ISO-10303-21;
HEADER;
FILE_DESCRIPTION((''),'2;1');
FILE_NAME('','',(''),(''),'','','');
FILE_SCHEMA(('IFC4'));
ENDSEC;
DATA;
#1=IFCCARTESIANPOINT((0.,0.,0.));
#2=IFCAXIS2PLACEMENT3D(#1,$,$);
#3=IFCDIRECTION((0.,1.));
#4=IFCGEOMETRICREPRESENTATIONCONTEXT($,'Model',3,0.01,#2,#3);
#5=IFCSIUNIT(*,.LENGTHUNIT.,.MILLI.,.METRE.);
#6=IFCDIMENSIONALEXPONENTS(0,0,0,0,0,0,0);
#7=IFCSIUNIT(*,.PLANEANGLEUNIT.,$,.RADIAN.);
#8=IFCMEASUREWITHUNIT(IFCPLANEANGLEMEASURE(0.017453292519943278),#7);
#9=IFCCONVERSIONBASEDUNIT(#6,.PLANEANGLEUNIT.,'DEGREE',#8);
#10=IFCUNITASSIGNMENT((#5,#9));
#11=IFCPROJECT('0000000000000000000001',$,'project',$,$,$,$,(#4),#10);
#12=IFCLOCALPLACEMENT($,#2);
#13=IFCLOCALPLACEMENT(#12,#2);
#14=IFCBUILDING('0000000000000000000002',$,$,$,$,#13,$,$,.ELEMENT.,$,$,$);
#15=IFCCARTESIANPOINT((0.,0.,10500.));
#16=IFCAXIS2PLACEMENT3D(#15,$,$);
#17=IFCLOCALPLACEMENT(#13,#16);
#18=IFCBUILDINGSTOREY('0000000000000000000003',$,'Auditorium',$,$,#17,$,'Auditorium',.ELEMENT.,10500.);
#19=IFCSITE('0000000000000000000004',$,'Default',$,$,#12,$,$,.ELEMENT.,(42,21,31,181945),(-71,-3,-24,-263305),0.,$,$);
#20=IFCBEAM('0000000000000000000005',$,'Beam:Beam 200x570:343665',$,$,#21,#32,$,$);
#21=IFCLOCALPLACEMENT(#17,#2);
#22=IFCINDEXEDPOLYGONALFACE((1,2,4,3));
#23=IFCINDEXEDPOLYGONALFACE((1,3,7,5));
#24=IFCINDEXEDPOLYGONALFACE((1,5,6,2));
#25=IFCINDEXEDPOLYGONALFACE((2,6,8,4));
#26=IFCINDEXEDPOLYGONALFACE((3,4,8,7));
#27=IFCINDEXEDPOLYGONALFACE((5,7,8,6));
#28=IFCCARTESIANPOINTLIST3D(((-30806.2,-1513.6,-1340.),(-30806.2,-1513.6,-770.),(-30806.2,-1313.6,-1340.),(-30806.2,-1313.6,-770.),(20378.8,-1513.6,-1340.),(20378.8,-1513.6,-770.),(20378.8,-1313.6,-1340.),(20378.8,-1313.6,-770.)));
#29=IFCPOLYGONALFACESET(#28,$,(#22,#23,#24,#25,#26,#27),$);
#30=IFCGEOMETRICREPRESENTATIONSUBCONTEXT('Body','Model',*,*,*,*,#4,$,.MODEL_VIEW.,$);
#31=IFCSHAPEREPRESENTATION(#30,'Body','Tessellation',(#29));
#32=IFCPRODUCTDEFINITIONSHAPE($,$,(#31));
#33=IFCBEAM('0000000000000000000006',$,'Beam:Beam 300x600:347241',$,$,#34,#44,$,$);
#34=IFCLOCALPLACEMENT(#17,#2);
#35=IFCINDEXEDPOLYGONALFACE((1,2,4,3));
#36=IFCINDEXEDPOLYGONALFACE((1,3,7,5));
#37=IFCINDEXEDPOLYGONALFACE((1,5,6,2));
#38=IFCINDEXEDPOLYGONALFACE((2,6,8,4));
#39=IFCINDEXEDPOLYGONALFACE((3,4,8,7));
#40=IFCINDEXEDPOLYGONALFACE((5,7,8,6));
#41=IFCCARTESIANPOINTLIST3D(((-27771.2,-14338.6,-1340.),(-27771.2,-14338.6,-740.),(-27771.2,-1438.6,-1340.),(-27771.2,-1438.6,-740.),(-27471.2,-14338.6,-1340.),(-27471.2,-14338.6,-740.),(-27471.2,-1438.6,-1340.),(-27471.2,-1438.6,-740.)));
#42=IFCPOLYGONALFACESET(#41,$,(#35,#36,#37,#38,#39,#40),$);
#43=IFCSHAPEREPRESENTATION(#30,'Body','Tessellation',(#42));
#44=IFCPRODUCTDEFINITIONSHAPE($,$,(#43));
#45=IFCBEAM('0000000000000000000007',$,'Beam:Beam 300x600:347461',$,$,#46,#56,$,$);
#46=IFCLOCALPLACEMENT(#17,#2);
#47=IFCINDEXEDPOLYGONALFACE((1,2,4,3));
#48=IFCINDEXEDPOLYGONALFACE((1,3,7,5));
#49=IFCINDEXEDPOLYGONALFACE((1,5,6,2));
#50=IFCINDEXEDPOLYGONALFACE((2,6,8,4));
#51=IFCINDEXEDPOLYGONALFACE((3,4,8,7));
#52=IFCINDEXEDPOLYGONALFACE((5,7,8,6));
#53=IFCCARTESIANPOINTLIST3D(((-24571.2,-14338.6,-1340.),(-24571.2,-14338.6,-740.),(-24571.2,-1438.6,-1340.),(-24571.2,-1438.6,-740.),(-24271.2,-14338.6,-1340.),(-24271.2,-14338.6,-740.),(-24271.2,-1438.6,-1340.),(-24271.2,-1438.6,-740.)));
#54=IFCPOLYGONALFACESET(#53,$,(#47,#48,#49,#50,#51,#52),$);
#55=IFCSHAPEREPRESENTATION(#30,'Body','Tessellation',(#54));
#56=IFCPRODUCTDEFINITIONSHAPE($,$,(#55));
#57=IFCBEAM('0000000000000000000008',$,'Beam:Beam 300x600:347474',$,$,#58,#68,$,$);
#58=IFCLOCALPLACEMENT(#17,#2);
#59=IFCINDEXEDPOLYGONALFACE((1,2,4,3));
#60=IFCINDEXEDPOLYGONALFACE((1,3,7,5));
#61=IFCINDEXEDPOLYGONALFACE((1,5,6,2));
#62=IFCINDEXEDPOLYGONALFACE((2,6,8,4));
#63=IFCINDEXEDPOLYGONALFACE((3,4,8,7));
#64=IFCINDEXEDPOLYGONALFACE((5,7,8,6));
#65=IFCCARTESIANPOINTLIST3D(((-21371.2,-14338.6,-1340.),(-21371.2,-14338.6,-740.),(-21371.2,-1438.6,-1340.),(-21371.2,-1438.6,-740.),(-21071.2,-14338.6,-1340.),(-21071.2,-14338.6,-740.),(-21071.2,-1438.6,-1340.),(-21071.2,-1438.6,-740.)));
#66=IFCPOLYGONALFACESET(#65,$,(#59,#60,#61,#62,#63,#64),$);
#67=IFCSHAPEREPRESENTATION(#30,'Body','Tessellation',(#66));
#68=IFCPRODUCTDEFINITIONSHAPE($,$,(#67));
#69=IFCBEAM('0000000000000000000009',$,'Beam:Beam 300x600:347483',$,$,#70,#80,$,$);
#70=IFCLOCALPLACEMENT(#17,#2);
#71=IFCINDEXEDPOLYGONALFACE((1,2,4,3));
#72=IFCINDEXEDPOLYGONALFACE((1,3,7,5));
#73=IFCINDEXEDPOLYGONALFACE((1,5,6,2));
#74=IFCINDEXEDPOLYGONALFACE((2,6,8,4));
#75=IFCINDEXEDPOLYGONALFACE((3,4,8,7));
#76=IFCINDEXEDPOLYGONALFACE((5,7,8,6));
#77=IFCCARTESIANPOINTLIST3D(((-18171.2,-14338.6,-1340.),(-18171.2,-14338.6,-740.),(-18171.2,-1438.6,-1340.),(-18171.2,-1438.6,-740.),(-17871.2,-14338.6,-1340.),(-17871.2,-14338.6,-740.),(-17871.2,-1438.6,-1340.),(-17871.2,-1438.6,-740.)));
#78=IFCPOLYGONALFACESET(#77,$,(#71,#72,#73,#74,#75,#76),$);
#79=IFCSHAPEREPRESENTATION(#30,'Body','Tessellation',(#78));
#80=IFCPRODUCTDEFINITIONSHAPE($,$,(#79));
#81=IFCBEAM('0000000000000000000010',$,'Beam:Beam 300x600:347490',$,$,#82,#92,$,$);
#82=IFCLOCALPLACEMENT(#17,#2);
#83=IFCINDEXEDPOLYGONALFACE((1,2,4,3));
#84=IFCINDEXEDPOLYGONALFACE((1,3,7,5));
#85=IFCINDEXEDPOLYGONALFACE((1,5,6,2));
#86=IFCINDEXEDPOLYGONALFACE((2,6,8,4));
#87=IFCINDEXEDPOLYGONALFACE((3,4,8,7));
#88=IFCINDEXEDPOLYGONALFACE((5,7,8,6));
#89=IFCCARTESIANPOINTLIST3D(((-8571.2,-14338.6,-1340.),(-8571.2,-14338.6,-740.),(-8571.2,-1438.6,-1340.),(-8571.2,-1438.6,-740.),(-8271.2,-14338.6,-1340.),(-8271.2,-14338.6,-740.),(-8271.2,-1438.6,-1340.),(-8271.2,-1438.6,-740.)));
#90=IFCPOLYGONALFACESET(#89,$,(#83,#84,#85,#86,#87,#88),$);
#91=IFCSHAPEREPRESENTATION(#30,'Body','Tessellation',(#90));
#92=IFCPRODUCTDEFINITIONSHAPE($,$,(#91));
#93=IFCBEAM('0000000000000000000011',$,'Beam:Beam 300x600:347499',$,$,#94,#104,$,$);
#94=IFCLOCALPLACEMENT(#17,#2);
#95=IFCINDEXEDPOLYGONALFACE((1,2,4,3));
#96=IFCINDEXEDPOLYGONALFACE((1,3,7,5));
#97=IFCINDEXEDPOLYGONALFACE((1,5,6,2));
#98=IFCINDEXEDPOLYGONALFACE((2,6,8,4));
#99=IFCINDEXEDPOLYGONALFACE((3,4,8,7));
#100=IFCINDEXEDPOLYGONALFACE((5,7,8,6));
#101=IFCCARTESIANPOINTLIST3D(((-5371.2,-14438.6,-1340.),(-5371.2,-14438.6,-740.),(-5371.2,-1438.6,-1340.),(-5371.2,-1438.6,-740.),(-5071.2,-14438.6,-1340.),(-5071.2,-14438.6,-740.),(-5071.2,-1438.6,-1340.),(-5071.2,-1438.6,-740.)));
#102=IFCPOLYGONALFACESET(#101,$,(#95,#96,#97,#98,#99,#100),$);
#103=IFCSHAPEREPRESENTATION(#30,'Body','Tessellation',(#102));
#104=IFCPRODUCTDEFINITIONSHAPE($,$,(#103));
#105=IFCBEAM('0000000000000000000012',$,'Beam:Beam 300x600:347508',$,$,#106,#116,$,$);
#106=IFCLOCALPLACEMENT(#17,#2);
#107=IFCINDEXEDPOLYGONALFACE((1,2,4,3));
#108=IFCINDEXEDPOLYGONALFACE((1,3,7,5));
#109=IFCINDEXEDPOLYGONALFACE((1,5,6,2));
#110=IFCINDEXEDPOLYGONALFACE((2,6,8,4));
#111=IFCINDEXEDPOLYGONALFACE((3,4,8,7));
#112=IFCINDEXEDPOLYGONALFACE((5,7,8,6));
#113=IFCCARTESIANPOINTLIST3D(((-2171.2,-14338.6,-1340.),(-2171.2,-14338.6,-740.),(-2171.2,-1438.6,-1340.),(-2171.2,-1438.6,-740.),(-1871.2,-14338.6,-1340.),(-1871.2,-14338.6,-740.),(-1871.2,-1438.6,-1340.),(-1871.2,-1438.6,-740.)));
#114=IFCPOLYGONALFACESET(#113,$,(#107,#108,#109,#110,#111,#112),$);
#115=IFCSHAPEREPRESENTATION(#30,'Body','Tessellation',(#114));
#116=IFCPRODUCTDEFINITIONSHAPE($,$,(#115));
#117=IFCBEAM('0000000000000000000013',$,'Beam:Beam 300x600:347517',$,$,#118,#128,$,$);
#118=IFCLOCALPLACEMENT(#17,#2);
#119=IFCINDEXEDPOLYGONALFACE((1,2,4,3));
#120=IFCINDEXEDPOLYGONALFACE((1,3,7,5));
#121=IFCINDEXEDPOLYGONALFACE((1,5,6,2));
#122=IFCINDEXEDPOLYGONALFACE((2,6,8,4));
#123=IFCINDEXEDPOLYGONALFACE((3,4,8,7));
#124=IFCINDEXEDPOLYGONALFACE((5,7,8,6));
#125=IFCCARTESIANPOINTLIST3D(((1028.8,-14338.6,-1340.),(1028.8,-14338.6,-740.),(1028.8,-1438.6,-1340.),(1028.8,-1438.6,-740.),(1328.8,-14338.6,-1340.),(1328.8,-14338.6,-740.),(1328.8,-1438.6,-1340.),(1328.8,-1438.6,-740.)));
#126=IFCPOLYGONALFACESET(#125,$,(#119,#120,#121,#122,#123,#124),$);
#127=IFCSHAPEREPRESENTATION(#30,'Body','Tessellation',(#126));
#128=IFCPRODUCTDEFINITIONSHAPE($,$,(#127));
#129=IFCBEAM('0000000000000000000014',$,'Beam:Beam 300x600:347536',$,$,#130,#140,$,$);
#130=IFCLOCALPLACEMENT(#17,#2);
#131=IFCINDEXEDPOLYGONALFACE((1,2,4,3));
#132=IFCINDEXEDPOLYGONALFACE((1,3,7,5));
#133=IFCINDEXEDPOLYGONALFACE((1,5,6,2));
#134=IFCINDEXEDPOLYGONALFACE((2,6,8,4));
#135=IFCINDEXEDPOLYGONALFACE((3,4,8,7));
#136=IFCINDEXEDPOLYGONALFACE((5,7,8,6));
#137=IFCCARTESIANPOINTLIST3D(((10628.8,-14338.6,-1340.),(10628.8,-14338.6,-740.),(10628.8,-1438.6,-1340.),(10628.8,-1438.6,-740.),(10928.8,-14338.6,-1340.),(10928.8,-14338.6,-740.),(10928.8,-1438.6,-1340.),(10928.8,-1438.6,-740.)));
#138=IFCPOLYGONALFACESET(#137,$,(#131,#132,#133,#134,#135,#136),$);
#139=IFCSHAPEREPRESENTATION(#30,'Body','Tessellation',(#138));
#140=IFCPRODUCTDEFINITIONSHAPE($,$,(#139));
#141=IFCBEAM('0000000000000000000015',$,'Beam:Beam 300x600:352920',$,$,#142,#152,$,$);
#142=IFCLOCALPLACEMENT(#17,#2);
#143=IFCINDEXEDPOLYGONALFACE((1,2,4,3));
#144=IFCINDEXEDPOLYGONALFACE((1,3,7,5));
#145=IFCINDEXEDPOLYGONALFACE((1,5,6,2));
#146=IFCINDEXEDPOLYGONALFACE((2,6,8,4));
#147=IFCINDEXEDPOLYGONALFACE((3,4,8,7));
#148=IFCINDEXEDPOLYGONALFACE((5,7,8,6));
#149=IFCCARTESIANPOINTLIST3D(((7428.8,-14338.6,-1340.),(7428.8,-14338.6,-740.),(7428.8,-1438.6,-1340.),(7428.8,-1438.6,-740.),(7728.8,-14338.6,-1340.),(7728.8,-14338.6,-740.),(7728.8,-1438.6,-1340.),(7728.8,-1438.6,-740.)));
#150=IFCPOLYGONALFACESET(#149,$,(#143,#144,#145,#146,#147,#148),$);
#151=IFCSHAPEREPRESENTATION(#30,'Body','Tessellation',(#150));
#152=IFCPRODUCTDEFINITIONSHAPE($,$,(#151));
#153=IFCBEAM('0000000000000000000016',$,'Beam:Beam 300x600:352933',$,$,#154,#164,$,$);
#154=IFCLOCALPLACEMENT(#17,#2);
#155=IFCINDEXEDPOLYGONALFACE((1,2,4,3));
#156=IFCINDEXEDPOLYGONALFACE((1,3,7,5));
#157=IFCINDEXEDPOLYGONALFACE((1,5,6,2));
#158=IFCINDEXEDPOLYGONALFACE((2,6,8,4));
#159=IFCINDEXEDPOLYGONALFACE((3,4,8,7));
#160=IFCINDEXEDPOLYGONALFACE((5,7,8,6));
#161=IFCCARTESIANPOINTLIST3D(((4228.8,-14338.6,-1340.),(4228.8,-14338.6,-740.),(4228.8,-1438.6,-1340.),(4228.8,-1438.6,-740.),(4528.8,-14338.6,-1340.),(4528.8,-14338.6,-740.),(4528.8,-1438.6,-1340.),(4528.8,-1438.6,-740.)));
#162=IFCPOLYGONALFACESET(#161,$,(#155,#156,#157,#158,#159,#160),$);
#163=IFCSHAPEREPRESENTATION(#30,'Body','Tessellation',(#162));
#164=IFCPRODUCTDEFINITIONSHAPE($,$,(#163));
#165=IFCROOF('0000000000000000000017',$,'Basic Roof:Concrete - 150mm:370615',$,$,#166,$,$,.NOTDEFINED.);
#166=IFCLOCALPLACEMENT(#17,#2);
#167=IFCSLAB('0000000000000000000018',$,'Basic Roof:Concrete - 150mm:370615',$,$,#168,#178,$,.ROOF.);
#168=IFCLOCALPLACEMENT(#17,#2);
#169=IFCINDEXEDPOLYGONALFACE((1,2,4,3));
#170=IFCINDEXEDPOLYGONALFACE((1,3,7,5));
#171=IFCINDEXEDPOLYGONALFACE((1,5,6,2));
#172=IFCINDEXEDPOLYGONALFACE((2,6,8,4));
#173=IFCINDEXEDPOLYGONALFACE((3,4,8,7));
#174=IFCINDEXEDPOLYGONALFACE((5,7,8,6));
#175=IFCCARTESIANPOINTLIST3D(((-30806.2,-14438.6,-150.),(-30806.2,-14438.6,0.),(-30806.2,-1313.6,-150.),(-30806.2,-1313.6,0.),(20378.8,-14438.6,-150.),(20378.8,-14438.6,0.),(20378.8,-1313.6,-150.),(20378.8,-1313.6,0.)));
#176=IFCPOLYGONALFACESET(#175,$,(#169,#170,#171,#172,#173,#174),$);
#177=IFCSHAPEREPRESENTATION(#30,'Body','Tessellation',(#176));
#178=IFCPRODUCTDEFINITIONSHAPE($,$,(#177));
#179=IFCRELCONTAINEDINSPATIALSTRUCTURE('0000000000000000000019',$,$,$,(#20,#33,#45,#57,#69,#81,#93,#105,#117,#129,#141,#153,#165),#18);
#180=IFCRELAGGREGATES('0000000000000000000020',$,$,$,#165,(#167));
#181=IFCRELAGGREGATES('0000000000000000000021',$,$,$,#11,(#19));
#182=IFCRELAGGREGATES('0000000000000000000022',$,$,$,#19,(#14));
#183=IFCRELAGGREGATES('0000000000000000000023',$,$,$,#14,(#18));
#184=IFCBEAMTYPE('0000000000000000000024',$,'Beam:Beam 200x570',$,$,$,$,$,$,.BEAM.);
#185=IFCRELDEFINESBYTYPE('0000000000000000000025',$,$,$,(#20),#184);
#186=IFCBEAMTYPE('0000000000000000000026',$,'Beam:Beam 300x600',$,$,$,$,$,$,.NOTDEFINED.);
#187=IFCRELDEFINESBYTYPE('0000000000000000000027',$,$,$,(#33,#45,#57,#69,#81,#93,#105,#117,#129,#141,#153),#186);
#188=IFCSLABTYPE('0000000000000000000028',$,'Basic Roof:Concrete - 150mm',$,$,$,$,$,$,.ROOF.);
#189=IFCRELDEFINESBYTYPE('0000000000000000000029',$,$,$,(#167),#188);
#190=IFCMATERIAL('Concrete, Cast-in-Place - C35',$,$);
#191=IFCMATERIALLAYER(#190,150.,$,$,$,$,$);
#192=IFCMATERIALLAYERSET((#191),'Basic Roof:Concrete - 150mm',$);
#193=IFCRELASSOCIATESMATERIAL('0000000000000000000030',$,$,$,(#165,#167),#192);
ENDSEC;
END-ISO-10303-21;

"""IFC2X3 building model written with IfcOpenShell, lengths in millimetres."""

from ifc_helpers import new_model, entity, si_unit, converted_unit, direction, frame, frame_2d, origin, origin_2d_with_axis, place, context, subcontext, project, spatial, rectangle, extrude, material, layer, layer_set, type_object, element, aggregate, save


model = new_model("IFC2X3")

# Units and contexts
model_context = context("Model", 3, precision=0.01, world=origin(), true_north=direction((0.0, 1.0)))
body_context = subcontext(model_context, "Body", "Model", "MODEL_VIEW")
ifc_project = project(units=[si_unit("LENGTHUNIT", "METRE", prefix="MILLI"), converted_unit("PLANEANGLEUNIT", "DEGREE", entity("IfcPlaneAngleMeasure", 0.017453292519943278), si_unit("PLANEANGLEUNIT", "RADIAN"), dimensions=[0, 0, 0, 0, 0, 0, 0])], contexts=[model_context])

# Site, building, storey
site_placement = place(None, origin())
site = spatial("IfcSite", under=ifc_project, at=site_placement, Name="Default", CompositionType="ELEMENT", RefLatitude=(42, 21, 31, 181945), RefLongitude=(-71, -3, -24, -263305), RefElevation=0.0)
building_placement = place(site_placement, origin())
building = spatial("IfcBuilding", under=site, at=building_placement, CompositionType="ELEMENT")
storey_placement = place(building_placement, frame((0.0, 0.0, 10500.0)))
storey = spatial("IfcBuildingStorey", under=building, at=storey_placement, Name="Auditorium", LongName="Auditorium", CompositionType="ELEMENT", Elevation=10500.0)

# Beams
beam_type_1 = type_object("IfcBeamType", Name="Beam:Beam 200x570", PredefinedType="BEAM")
beam_1_placement = place(storey_placement, frame((-30806.2, -1438.6, -770.0)))
element("IfcBeam", 1, at=beam_1_placement, inside=storey, type_object=beam_type_1, Name="Beam:Beam 200x570:343665", context=body_context, shape_type="SweptSolid", body=[
    extrude(rectangle(XDim=570.0, YDim=200.0, at=origin_2d_with_axis()), frame((0.0, 25.0, -285.0), z_axis=(1.0, 0.0, 0.0), x_axis=(0.0, 0.0, -1.0)), (0.0, 0.0, 1.0), 51185.0),
])
beam_type_2 = type_object("IfcBeamType", Name="Beam:Beam 300x600", PredefinedType="NOTDEFINED")
for number, where, z_axis, x_axis, name in (
    (2, (-27596.2, -1438.6, -740.0), (0.0, 0.0, 1.0), (0.0, -1.0, 0.0), "Beam:Beam 300x600:347241"),
    (3, (-24396.2, -1438.6, -740.0), (0.0, 0.0, 1.0), (0.0, -1.0, 0.0), "Beam:Beam 300x600:347461"),
):
    element("IfcBeam", number, at=place(storey_placement, frame(where, z_axis=z_axis, x_axis=x_axis)), inside=storey, type_object=beam_type_2, Name=name, context=body_context, shape_type="SweptSolid", body=[
        extrude(rectangle(XDim=600.0, YDim=300.0, at=origin_2d_with_axis()), frame((0.0, -25.0, -300.0), z_axis=(1.0, 0.0, 0.0), x_axis=(0.0, 0.0, -1.0)), (0.0, 0.0, 1.0), 12900.0),
    ])
beam_2_placement = place(storey_placement, frame((-21196.2, -1438.6, -740.0), z_axis=(0.0, 0.0, 1.0), x_axis=(0.0, -1.0, 0.0)))
element("IfcBeam", 4, at=beam_2_placement, inside=storey, type_object=beam_type_2, Name="Beam:Beam 300x600:347474", context=body_context, shape_type="SweptSolid", body=[
    extrude(rectangle(XDim=600.0, YDim=300.0, at=frame_2d((0.0, 0.0), x_axis=(1.0, 0.0))), frame((0.0, -25.0, -300.0), z_axis=(1.0, 0.0, 0.0), x_axis=(0.0, 0.0, -1.0)), (0.0, 0.0, 1.0), 12900.0),
])
beam_3_placement = place(storey_placement, frame((-17996.2, -1438.6, -740.0), z_axis=(0.0, 0.0, 1.0), x_axis=(0.0, -1.0, 0.0)))
element("IfcBeam", 5, at=beam_3_placement, inside=storey, type_object=beam_type_2, Name="Beam:Beam 300x600:347483", context=body_context, shape_type="SweptSolid", body=[
    extrude(rectangle(XDim=600.0, YDim=300.0, at=origin_2d_with_axis()), frame((0.0, -25.0, -300.0), z_axis=(1.0, 0.0, 0.0), x_axis=(0.0, 0.0, -1.0)), (0.0, 0.0, 1.0), 12900.0),
])
beam_4_placement = place(storey_placement, frame((-8396.2, -1438.6, -740.0), z_axis=(0.0, 0.0, 1.0), x_axis=(0.0, -1.0, 0.0)))
element("IfcBeam", 6, at=beam_4_placement, inside=storey, type_object=beam_type_2, Name="Beam:Beam 300x600:347490", context=body_context, shape_type="SweptSolid", body=[
    extrude(rectangle(XDim=600.0, YDim=300.0, at=frame_2d((0.0, 0.0), x_axis=(1.0, 0.0))), frame((0.0, -25.0, -300.0), z_axis=(1.0, 0.0, 0.0), x_axis=(0.0, 0.0, -1.0)), (0.0, 0.0, 1.0), 12900.0),
])
beam_5_placement = place(storey_placement, frame((-5196.2, -1438.6, -740.0), z_axis=(0.0, 0.0, 1.0), x_axis=(0.0, -1.0, 0.0)))
element("IfcBeam", 7, at=beam_5_placement, inside=storey, type_object=beam_type_2, Name="Beam:Beam 300x600:347499", context=body_context, shape_type="SweptSolid", body=[
    extrude(rectangle(XDim=600.0, YDim=300.0, at=frame_2d((0.0, 0.0), x_axis=(1.0, 0.0))), frame((0.0, -25.0, -300.0), z_axis=(1.0, 0.0, 0.0), x_axis=(0.0, 0.0, -1.0)), (0.0, 0.0, 1.0), 13000.0),
])
beam_6_placement = place(storey_placement, frame((-1996.2, -1438.6, -740.0), z_axis=(0.0, 0.0, 1.0), x_axis=(0.0, -1.0, 0.0)))
element("IfcBeam", 8, at=beam_6_placement, inside=storey, type_object=beam_type_2, Name="Beam:Beam 300x600:347508", context=body_context, shape_type="SweptSolid", body=[
    extrude(rectangle(XDim=600.0, YDim=300.0, at=frame_2d((0.0, 0.0), x_axis=(1.0, 0.0))), frame((0.0, -25.0, -300.0), z_axis=(1.0, 0.0, 0.0), x_axis=(0.0, 0.0, -1.0)), (0.0, 0.0, 1.0), 12900.0),
])
beam_7_placement = place(storey_placement, frame((1203.8, -1438.6, -740.0), z_axis=(0.0, 0.0, 1.0), x_axis=(0.0, -1.0, 0.0)))
element("IfcBeam", 9, at=beam_7_placement, inside=storey, type_object=beam_type_2, Name="Beam:Beam 300x600:347517", context=body_context, shape_type="SweptSolid", body=[
    extrude(rectangle(XDim=600.0, YDim=300.0, at=origin_2d_with_axis()), frame((0.0, -25.0, -300.0), z_axis=(1.0, 0.0, 0.0), x_axis=(0.0, 0.0, -1.0)), (0.0, 0.0, 1.0), 12900.0),
])
beam_8_placement = place(storey_placement, frame((10803.8, -1438.6, -740.0), z_axis=(0.0, 0.0, 1.0), x_axis=(0.0, -1.0, 0.0)))
element("IfcBeam", 10, at=beam_8_placement, inside=storey, type_object=beam_type_2, Name="Beam:Beam 300x600:347536", context=body_context, shape_type="SweptSolid", body=[
    extrude(rectangle(XDim=600.0, YDim=300.0, at=origin_2d_with_axis()), frame((0.0, -25.0, -300.0), z_axis=(1.0, 0.0, 0.0), x_axis=(0.0, 0.0, -1.0)), (0.0, 0.0, 1.0), 12900.0),
])
for number, where, z_axis, x_axis, name in (
    (11, (7603.8, -1438.6, -740.0), (0.0, 0.0, 1.0), (0.0, -1.0, 0.0), "Beam:Beam 300x600:352920"),
    (12, (4403.8, -1438.6, -740.0), (0.0, 0.0, 1.0), (0.0, -1.0, 0.0), "Beam:Beam 300x600:352933"),
):
    element("IfcBeam", number, at=place(storey_placement, frame(where, z_axis=z_axis, x_axis=x_axis)), inside=storey, type_object=beam_type_2, Name=name, context=body_context, shape_type="SweptSolid", body=[
        extrude(rectangle(XDim=600.0, YDim=300.0, at=frame_2d((0.0, 0.0), x_axis=(1.0, 0.0))), frame((0.0, -25.0, -300.0), z_axis=(1.0, 0.0, 0.0), x_axis=(0.0, 0.0, -1.0)), (0.0, 0.0, 1.0), 12900.0),
    ])

# Roof, slab
ifc_material_1 = material(Name="Concrete, Cast-in-Place - C35")
ifc_layer = layer(ifc_material_1, 150.0)
ifc_layer_set = layer_set([ifc_layer], Name="Basic Roof:Concrete - 150mm")
roof_placement = place(storey_placement, frame((-30806.2, -14438.6, -150.0)))
roof = element("IfcRoof", 13, at=roof_placement, inside=storey, material=ifc_layer_set, Name="Basic Roof:Concrete - 150mm:370615", ShapeType="NOTDEFINED")
slab_type = type_object("IfcSlabType", Name="Basic Roof:Concrete - 150mm", PredefinedType="ROOF")
slab_placement = place(roof_placement, origin())
slab = element("IfcSlab", 14, at=slab_placement, type_object=slab_type, material=ifc_layer_set, Name="Basic Roof:Concrete - 150mm:370615", PredefinedType="ROOF", context=body_context, shape_type="SweptSolid", body=[
    extrude(rectangle(XDim=51185.0, YDim=13125.0, at=frame_2d((0.0, 0.0), x_axis=(1.0, 0.0))), frame((25592.5, 6562.5, 0.0)), (0.0, 0.0, 1.0), 150.0),
])
aggregate(roof, [slab])

save(model, "model.ifc")
